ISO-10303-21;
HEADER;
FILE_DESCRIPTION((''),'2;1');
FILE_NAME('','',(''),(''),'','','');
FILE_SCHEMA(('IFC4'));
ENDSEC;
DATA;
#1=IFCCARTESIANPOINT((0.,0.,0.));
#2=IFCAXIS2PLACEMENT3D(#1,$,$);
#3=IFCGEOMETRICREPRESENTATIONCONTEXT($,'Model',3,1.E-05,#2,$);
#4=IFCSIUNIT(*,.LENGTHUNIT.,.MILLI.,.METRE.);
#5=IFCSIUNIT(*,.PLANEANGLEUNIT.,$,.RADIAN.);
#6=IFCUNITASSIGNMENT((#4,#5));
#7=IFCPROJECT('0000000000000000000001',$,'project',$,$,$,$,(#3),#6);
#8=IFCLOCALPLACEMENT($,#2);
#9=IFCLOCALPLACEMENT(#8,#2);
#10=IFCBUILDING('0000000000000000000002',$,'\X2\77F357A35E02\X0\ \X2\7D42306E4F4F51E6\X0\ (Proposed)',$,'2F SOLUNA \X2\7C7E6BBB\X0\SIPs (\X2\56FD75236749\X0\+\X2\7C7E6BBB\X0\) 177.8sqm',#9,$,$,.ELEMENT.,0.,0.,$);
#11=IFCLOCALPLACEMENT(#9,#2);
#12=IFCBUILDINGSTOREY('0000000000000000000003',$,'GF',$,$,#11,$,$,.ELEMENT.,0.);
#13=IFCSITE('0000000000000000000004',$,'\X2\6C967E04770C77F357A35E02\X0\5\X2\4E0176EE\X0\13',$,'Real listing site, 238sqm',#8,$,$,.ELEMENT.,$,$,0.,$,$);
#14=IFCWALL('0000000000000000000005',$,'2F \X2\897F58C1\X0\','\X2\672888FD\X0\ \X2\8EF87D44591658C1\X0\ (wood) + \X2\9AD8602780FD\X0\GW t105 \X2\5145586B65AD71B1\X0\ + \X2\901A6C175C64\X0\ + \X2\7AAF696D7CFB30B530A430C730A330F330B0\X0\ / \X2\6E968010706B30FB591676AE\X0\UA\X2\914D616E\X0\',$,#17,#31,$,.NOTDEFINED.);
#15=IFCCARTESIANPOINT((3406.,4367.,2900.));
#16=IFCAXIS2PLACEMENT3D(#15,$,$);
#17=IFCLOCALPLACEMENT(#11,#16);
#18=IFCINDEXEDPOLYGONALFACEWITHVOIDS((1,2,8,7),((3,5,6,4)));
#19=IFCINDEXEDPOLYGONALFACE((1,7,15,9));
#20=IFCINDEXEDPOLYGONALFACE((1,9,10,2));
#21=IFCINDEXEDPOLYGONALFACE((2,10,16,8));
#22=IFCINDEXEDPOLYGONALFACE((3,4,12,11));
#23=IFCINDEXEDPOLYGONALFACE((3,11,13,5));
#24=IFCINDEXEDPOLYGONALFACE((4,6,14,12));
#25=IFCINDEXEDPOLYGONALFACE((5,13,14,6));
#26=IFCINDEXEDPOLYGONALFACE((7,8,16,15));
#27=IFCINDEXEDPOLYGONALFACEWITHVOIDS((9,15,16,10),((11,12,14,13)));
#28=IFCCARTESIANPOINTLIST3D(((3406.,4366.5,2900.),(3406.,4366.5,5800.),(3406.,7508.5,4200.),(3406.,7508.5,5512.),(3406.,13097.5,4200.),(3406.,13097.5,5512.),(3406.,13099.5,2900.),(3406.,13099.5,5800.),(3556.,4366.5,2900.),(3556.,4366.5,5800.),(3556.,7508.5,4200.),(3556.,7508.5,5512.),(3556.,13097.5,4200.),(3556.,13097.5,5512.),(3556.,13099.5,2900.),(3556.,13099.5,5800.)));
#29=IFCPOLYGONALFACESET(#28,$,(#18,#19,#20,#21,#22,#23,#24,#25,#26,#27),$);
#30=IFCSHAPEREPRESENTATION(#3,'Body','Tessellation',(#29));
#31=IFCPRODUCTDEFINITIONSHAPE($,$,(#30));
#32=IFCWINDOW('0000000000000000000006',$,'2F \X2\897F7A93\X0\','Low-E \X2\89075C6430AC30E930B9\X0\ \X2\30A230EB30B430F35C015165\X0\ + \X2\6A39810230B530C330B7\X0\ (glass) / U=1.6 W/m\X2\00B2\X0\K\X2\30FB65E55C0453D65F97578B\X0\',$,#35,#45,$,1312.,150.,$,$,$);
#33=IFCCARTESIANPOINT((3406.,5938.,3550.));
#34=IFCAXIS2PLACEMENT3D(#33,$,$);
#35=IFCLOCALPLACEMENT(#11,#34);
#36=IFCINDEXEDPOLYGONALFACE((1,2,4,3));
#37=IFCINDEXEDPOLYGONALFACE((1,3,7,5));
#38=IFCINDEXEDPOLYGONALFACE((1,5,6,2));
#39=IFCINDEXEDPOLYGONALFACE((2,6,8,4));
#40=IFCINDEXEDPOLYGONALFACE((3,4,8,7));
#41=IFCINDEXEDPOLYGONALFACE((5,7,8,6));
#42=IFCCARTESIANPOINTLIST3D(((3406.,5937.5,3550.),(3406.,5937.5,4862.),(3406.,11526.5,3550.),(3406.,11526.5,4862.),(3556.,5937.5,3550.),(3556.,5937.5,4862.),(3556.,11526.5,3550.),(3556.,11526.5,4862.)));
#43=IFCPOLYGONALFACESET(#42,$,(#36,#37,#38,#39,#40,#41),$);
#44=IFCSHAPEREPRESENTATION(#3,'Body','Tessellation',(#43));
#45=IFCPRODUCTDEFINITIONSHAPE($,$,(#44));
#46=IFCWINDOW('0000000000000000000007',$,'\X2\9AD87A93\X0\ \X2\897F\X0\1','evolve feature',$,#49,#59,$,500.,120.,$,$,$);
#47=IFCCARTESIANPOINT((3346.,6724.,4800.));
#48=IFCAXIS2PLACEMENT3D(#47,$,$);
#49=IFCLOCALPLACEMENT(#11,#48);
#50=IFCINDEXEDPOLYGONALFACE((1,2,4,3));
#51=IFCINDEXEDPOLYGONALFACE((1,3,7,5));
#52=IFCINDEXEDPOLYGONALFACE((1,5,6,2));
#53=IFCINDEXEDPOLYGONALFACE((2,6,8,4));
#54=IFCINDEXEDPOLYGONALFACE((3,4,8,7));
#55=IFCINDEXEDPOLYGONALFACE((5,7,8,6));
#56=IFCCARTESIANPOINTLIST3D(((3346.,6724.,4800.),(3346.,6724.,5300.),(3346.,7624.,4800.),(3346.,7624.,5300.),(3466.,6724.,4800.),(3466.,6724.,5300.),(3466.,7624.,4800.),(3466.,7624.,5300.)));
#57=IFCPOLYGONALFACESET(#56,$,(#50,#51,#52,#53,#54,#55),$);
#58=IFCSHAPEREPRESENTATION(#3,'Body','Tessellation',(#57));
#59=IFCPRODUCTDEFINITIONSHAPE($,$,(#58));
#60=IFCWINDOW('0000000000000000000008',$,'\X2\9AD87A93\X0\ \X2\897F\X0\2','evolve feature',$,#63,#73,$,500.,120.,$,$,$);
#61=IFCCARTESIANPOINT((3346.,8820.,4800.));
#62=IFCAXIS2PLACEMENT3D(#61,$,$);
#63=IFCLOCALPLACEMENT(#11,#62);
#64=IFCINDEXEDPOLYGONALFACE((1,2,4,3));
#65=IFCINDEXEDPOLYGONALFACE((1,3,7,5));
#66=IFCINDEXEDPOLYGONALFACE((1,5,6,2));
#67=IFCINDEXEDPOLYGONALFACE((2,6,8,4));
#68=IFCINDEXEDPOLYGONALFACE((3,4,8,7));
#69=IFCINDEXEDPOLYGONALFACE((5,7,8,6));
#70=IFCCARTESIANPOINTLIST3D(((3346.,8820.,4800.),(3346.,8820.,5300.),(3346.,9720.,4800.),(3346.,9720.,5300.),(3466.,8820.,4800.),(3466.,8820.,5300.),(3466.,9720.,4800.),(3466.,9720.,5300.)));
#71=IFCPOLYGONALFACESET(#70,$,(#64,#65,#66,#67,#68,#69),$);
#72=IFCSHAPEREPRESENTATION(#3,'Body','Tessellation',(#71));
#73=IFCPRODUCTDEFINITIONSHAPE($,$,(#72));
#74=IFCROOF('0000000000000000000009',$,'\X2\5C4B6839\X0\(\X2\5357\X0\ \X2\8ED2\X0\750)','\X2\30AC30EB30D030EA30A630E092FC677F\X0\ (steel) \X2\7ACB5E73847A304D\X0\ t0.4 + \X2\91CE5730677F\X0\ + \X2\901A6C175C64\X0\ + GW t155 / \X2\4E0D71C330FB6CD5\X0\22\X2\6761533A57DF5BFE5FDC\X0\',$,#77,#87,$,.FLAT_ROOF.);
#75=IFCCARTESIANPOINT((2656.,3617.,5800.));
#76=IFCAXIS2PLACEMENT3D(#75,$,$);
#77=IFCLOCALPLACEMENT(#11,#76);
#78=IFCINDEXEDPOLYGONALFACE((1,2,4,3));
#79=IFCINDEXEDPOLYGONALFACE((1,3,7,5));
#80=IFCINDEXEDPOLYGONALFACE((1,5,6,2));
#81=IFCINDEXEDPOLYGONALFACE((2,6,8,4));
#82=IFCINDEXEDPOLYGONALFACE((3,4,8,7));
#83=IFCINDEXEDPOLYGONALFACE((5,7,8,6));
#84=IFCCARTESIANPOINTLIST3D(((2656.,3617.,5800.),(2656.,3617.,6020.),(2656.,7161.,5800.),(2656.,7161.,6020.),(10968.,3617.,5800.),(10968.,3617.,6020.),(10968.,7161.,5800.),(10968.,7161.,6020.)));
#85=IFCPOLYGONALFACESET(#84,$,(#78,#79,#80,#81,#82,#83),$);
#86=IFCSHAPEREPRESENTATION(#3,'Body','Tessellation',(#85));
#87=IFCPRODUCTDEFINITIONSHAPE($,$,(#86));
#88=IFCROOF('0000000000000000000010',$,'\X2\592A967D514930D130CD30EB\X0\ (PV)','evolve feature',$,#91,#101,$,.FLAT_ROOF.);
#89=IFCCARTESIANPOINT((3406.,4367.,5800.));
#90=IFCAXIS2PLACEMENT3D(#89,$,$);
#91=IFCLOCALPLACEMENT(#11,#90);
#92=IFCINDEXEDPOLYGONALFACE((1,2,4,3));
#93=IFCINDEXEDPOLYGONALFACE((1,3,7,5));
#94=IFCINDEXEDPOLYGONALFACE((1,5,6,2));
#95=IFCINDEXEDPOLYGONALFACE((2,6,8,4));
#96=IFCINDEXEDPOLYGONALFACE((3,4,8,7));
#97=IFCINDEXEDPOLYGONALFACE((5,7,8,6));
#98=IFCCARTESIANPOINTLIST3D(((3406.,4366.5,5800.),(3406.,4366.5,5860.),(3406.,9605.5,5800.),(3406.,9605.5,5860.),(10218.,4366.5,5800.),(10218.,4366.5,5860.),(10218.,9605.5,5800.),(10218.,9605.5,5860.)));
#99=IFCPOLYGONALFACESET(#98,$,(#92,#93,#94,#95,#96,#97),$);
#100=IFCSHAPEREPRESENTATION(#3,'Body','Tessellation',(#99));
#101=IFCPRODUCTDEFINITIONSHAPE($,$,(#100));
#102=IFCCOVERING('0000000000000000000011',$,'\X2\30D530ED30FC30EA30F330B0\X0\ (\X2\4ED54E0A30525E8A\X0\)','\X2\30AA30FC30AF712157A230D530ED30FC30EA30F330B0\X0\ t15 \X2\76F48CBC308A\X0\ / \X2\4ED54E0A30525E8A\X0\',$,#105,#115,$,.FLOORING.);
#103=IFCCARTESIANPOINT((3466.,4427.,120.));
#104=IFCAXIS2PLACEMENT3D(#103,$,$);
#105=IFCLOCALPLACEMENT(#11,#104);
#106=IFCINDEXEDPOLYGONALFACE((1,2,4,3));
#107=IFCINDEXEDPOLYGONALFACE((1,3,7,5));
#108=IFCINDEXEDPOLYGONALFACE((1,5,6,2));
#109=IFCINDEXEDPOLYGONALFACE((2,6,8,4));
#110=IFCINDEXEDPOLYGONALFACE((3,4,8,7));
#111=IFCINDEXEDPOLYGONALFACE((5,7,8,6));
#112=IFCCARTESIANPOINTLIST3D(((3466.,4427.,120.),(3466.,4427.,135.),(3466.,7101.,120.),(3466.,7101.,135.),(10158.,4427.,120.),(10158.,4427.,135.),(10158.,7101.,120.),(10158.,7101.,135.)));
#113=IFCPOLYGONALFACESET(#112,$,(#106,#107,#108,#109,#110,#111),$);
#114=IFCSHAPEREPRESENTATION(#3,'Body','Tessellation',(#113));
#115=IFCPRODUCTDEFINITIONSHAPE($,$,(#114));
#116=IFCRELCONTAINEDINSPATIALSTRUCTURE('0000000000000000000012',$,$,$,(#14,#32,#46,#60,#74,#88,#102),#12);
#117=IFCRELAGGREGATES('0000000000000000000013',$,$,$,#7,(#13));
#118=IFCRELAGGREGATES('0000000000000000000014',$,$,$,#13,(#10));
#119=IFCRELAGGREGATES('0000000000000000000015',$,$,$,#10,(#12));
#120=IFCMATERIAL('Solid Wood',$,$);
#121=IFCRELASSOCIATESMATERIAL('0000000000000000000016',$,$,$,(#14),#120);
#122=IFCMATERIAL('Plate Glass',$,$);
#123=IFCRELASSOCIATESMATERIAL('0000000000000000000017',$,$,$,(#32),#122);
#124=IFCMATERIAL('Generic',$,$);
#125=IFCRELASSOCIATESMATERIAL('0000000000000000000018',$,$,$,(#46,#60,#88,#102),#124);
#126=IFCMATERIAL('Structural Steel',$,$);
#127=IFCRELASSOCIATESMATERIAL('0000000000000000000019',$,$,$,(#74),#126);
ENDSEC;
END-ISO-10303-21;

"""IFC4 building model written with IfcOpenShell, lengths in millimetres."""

from ifc_helpers import new_model, si_unit, frame, frame_2d, origin, place, context, project, spatial, rectangle, extrude, material, element, fill, save


model = new_model("IFC4")

# Units and contexts
model_context = context("Model", 3, precision=1e-05, world=origin())
ifc_project = project(units=[si_unit("LENGTHUNIT", "METRE", prefix="MILLI"), si_unit("PLANEANGLEUNIT", "RADIAN")], contexts=[model_context])

# Site, building, storey
site_placement = place(None, origin())
site = spatial("IfcSite", under=ifc_project, at=site_placement, Name="沖縄県石垣市5丁目13", ObjectType="Real listing site, 238sqm", CompositionType="ELEMENT", RefElevation=0.0)
building_placement = place(site_placement, origin())
building = spatial("IfcBuilding", under=site, at=building_placement, Name="石垣市 終の住処 (Proposed)", ObjectType="2F SOLUNA 籾殻SIPs (国産杉+籾殻) 177.8sqm", CompositionType="ELEMENT", ElevationOfRefHeight=0.0, ElevationOfTerrain=0.0)
storey_placement = place(building_placement, origin())
storey = spatial("IfcBuildingStorey", under=building, at=storey_placement, Name="GF", CompositionType="ELEMENT", Elevation=0.0)

# Shared definitions
ifc_material_1 = material(Name="Solid Wood")
ifc_material_2 = material(Name="Generic")

# Shared definitions
ifc_material_3 = material(Name="Plate Glass")

# Wall, openings, windows
wall_1_placement = place(storey_placement, frame((3406.0, 4367.0, 2900.0)))
wall_1 = element("IfcWall", 1, at=wall_1_placement, inside=storey, material=ifc_material_1, Name="2F 西壁", Description="木製 軸組外壁 (wood) + 高性能GW t105 充填断熱 + 通気層 + 窯業系サイディング / 準耐火・外皮UA配慮", PredefinedType="NOTDEFINED", context=model_context, shape_type="SweptSolid", body=[
    extrude(rectangle(XDim=150.0, YDim=8733.0, at=frame_2d((75.0, 4366.0))), frame((3406.0, 4367.0, 2900.0)), (0.0, 0.0, 1.0), 2900.0),
])
opening_1_placement = place(storey_placement, frame((3406.0, 5938.0, 3550.0)))
opening_1 = element("IfcOpeningElement", 2, at=opening_1_placement, cuts=wall_1, PredefinedType="NOTDEFINED", context=model_context, shape_type="SweptSolid", body=[
    extrude(rectangle(XDim=150.0, YDim=5589.0, at=frame_2d((75.0, 2794.0))), frame((3406.0, 5938.0, 3550.0)), (0.0, 0.0, 1.0), 1312.0),
])
opening_2_placement = place(storey_placement, frame((3346.0, 6724.0, 4800.0)))
opening_2 = element("IfcOpeningElement", 3, at=opening_2_placement, cuts=wall_1, PredefinedType="NOTDEFINED", context=model_context, shape_type="SweptSolid", body=[
    extrude(rectangle(XDim=120.0, YDim=900.0, at=frame_2d((60.0, 450.0))), frame((3346.0, 6724.0, 4800.0)), (0.0, 0.0, 1.0), 500.0),
])
opening_3_placement = place(storey_placement, frame((3346.0, 8820.0, 4800.0)))
opening_3 = element("IfcOpeningElement", 4, at=opening_3_placement, cuts=wall_1, PredefinedType="NOTDEFINED", context=model_context, shape_type="SweptSolid", body=[
    extrude(rectangle(XDim=120.0, YDim=900.0, at=frame_2d((60.0, 450.0))), frame((3346.0, 8820.0, 4800.0)), (0.0, 0.0, 1.0), 500.0),
])
window_1_placement = place(storey_placement, frame((3406.0, 5938.0, 3550.0)))
window_1 = element("IfcWindow", 5, at=window_1_placement, inside=storey, material=ifc_material_3, Name="2F 西窓", Description="Low-E 複層ガラス アルゴン封入 + 樹脂サッシ (glass) / U=1.6 W/m²K・日射取得型", OverallHeight=1312.0, OverallWidth=150.0, context=model_context, shape_type="SweptSolid", body=[
    extrude(rectangle(XDim=150.0, YDim=5589.0, at=frame_2d((75.0, 2794.0))), frame((3406.0, 5938.0, 3550.0)), (0.0, 0.0, 1.0), 1312.0),
])
fill(opening_1, window_1)
window_2_placement = place(storey_placement, frame((3346.0, 6724.0, 4800.0)))
window_2 = element("IfcWindow", 6, at=window_2_placement, inside=storey, material=ifc_material_2, Name="高窓 西1", Description="evolve feature", OverallHeight=500.0, OverallWidth=120.0, context=model_context, shape_type="SweptSolid", body=[
    extrude(rectangle(XDim=120.0, YDim=900.0, at=frame_2d((60.0, 450.0))), frame((3346.0, 6724.0, 4800.0)), (0.0, 0.0, 1.0), 500.0),
])
fill(opening_2, window_2)
window_3_placement = place(storey_placement, frame((3346.0, 8820.0, 4800.0)))
window_3 = element("IfcWindow", 7, at=window_3_placement, inside=storey, material=ifc_material_2, Name="高窓 西2", Description="evolve feature", OverallHeight=500.0, OverallWidth=120.0, context=model_context, shape_type="SweptSolid", body=[
    extrude(rectangle(XDim=120.0, YDim=900.0, at=frame_2d((60.0, 450.0))), frame((3346.0, 8820.0, 4800.0)), (0.0, 0.0, 1.0), 500.0),
])
fill(opening_3, window_3)

# Roofs
ifc_material_4 = material(Name="Structural Steel")
roof_1_placement = place(storey_placement, frame((2656.0, 3617.0, 5800.0)))
element("IfcRoof", 8, at=roof_1_placement, inside=storey, material=ifc_material_4, Name="屋根(南 軒750)", Description="ガルバリウム鋼板 (steel) 立平葺き t0.4 + 野地板 + 通気層 + GW t155 / 不燃・法22条区域対応", PredefinedType="FLAT_ROOF", context=model_context, shape_type="SweptSolid", body=[
    extrude(rectangle(XDim=8312.0, YDim=3544.0, at=frame_2d((4156.0, 1772.0))), frame((2656.0, 3617.0, 5800.0)), (0.0, 0.0, 1.0), 220.0),
])
roof_2_placement = place(storey_placement, frame((3406.0, 4367.0, 5800.0)))
element("IfcRoof", 9, at=roof_2_placement, inside=storey, material=ifc_material_2, Name="太陽光パネル (PV)", Description="evolve feature", PredefinedType="FLAT_ROOF", context=model_context, shape_type="SweptSolid", body=[
    extrude(rectangle(XDim=6812.0, YDim=5239.0, at=frame_2d((3406.0, 2619.0))), frame((3406.0, 4367.0, 5800.0)), (0.0, 0.0, 1.0), 60.0),
])

# Covering
covering_placement = place(storey_placement, frame((3466.0, 4427.0, 120.0)))
element("IfcCovering", 10, at=covering_placement, inside=storey, material=ifc_material_2, Name="フローリング (仕上げ床)", Description="オーク無垢フローリング t15 直貼り / 仕上げ床", PredefinedType="FLOORING", context=model_context, shape_type="SweptSolid", body=[
    extrude(rectangle(XDim=6692.0, YDim=2674.0, at=frame_2d((3346.0, 1337.0))), frame((3466.0, 4427.0, 120.0)), (0.0, 0.0, 1.0), 15.0),
])

save(model, "model.ifc")
